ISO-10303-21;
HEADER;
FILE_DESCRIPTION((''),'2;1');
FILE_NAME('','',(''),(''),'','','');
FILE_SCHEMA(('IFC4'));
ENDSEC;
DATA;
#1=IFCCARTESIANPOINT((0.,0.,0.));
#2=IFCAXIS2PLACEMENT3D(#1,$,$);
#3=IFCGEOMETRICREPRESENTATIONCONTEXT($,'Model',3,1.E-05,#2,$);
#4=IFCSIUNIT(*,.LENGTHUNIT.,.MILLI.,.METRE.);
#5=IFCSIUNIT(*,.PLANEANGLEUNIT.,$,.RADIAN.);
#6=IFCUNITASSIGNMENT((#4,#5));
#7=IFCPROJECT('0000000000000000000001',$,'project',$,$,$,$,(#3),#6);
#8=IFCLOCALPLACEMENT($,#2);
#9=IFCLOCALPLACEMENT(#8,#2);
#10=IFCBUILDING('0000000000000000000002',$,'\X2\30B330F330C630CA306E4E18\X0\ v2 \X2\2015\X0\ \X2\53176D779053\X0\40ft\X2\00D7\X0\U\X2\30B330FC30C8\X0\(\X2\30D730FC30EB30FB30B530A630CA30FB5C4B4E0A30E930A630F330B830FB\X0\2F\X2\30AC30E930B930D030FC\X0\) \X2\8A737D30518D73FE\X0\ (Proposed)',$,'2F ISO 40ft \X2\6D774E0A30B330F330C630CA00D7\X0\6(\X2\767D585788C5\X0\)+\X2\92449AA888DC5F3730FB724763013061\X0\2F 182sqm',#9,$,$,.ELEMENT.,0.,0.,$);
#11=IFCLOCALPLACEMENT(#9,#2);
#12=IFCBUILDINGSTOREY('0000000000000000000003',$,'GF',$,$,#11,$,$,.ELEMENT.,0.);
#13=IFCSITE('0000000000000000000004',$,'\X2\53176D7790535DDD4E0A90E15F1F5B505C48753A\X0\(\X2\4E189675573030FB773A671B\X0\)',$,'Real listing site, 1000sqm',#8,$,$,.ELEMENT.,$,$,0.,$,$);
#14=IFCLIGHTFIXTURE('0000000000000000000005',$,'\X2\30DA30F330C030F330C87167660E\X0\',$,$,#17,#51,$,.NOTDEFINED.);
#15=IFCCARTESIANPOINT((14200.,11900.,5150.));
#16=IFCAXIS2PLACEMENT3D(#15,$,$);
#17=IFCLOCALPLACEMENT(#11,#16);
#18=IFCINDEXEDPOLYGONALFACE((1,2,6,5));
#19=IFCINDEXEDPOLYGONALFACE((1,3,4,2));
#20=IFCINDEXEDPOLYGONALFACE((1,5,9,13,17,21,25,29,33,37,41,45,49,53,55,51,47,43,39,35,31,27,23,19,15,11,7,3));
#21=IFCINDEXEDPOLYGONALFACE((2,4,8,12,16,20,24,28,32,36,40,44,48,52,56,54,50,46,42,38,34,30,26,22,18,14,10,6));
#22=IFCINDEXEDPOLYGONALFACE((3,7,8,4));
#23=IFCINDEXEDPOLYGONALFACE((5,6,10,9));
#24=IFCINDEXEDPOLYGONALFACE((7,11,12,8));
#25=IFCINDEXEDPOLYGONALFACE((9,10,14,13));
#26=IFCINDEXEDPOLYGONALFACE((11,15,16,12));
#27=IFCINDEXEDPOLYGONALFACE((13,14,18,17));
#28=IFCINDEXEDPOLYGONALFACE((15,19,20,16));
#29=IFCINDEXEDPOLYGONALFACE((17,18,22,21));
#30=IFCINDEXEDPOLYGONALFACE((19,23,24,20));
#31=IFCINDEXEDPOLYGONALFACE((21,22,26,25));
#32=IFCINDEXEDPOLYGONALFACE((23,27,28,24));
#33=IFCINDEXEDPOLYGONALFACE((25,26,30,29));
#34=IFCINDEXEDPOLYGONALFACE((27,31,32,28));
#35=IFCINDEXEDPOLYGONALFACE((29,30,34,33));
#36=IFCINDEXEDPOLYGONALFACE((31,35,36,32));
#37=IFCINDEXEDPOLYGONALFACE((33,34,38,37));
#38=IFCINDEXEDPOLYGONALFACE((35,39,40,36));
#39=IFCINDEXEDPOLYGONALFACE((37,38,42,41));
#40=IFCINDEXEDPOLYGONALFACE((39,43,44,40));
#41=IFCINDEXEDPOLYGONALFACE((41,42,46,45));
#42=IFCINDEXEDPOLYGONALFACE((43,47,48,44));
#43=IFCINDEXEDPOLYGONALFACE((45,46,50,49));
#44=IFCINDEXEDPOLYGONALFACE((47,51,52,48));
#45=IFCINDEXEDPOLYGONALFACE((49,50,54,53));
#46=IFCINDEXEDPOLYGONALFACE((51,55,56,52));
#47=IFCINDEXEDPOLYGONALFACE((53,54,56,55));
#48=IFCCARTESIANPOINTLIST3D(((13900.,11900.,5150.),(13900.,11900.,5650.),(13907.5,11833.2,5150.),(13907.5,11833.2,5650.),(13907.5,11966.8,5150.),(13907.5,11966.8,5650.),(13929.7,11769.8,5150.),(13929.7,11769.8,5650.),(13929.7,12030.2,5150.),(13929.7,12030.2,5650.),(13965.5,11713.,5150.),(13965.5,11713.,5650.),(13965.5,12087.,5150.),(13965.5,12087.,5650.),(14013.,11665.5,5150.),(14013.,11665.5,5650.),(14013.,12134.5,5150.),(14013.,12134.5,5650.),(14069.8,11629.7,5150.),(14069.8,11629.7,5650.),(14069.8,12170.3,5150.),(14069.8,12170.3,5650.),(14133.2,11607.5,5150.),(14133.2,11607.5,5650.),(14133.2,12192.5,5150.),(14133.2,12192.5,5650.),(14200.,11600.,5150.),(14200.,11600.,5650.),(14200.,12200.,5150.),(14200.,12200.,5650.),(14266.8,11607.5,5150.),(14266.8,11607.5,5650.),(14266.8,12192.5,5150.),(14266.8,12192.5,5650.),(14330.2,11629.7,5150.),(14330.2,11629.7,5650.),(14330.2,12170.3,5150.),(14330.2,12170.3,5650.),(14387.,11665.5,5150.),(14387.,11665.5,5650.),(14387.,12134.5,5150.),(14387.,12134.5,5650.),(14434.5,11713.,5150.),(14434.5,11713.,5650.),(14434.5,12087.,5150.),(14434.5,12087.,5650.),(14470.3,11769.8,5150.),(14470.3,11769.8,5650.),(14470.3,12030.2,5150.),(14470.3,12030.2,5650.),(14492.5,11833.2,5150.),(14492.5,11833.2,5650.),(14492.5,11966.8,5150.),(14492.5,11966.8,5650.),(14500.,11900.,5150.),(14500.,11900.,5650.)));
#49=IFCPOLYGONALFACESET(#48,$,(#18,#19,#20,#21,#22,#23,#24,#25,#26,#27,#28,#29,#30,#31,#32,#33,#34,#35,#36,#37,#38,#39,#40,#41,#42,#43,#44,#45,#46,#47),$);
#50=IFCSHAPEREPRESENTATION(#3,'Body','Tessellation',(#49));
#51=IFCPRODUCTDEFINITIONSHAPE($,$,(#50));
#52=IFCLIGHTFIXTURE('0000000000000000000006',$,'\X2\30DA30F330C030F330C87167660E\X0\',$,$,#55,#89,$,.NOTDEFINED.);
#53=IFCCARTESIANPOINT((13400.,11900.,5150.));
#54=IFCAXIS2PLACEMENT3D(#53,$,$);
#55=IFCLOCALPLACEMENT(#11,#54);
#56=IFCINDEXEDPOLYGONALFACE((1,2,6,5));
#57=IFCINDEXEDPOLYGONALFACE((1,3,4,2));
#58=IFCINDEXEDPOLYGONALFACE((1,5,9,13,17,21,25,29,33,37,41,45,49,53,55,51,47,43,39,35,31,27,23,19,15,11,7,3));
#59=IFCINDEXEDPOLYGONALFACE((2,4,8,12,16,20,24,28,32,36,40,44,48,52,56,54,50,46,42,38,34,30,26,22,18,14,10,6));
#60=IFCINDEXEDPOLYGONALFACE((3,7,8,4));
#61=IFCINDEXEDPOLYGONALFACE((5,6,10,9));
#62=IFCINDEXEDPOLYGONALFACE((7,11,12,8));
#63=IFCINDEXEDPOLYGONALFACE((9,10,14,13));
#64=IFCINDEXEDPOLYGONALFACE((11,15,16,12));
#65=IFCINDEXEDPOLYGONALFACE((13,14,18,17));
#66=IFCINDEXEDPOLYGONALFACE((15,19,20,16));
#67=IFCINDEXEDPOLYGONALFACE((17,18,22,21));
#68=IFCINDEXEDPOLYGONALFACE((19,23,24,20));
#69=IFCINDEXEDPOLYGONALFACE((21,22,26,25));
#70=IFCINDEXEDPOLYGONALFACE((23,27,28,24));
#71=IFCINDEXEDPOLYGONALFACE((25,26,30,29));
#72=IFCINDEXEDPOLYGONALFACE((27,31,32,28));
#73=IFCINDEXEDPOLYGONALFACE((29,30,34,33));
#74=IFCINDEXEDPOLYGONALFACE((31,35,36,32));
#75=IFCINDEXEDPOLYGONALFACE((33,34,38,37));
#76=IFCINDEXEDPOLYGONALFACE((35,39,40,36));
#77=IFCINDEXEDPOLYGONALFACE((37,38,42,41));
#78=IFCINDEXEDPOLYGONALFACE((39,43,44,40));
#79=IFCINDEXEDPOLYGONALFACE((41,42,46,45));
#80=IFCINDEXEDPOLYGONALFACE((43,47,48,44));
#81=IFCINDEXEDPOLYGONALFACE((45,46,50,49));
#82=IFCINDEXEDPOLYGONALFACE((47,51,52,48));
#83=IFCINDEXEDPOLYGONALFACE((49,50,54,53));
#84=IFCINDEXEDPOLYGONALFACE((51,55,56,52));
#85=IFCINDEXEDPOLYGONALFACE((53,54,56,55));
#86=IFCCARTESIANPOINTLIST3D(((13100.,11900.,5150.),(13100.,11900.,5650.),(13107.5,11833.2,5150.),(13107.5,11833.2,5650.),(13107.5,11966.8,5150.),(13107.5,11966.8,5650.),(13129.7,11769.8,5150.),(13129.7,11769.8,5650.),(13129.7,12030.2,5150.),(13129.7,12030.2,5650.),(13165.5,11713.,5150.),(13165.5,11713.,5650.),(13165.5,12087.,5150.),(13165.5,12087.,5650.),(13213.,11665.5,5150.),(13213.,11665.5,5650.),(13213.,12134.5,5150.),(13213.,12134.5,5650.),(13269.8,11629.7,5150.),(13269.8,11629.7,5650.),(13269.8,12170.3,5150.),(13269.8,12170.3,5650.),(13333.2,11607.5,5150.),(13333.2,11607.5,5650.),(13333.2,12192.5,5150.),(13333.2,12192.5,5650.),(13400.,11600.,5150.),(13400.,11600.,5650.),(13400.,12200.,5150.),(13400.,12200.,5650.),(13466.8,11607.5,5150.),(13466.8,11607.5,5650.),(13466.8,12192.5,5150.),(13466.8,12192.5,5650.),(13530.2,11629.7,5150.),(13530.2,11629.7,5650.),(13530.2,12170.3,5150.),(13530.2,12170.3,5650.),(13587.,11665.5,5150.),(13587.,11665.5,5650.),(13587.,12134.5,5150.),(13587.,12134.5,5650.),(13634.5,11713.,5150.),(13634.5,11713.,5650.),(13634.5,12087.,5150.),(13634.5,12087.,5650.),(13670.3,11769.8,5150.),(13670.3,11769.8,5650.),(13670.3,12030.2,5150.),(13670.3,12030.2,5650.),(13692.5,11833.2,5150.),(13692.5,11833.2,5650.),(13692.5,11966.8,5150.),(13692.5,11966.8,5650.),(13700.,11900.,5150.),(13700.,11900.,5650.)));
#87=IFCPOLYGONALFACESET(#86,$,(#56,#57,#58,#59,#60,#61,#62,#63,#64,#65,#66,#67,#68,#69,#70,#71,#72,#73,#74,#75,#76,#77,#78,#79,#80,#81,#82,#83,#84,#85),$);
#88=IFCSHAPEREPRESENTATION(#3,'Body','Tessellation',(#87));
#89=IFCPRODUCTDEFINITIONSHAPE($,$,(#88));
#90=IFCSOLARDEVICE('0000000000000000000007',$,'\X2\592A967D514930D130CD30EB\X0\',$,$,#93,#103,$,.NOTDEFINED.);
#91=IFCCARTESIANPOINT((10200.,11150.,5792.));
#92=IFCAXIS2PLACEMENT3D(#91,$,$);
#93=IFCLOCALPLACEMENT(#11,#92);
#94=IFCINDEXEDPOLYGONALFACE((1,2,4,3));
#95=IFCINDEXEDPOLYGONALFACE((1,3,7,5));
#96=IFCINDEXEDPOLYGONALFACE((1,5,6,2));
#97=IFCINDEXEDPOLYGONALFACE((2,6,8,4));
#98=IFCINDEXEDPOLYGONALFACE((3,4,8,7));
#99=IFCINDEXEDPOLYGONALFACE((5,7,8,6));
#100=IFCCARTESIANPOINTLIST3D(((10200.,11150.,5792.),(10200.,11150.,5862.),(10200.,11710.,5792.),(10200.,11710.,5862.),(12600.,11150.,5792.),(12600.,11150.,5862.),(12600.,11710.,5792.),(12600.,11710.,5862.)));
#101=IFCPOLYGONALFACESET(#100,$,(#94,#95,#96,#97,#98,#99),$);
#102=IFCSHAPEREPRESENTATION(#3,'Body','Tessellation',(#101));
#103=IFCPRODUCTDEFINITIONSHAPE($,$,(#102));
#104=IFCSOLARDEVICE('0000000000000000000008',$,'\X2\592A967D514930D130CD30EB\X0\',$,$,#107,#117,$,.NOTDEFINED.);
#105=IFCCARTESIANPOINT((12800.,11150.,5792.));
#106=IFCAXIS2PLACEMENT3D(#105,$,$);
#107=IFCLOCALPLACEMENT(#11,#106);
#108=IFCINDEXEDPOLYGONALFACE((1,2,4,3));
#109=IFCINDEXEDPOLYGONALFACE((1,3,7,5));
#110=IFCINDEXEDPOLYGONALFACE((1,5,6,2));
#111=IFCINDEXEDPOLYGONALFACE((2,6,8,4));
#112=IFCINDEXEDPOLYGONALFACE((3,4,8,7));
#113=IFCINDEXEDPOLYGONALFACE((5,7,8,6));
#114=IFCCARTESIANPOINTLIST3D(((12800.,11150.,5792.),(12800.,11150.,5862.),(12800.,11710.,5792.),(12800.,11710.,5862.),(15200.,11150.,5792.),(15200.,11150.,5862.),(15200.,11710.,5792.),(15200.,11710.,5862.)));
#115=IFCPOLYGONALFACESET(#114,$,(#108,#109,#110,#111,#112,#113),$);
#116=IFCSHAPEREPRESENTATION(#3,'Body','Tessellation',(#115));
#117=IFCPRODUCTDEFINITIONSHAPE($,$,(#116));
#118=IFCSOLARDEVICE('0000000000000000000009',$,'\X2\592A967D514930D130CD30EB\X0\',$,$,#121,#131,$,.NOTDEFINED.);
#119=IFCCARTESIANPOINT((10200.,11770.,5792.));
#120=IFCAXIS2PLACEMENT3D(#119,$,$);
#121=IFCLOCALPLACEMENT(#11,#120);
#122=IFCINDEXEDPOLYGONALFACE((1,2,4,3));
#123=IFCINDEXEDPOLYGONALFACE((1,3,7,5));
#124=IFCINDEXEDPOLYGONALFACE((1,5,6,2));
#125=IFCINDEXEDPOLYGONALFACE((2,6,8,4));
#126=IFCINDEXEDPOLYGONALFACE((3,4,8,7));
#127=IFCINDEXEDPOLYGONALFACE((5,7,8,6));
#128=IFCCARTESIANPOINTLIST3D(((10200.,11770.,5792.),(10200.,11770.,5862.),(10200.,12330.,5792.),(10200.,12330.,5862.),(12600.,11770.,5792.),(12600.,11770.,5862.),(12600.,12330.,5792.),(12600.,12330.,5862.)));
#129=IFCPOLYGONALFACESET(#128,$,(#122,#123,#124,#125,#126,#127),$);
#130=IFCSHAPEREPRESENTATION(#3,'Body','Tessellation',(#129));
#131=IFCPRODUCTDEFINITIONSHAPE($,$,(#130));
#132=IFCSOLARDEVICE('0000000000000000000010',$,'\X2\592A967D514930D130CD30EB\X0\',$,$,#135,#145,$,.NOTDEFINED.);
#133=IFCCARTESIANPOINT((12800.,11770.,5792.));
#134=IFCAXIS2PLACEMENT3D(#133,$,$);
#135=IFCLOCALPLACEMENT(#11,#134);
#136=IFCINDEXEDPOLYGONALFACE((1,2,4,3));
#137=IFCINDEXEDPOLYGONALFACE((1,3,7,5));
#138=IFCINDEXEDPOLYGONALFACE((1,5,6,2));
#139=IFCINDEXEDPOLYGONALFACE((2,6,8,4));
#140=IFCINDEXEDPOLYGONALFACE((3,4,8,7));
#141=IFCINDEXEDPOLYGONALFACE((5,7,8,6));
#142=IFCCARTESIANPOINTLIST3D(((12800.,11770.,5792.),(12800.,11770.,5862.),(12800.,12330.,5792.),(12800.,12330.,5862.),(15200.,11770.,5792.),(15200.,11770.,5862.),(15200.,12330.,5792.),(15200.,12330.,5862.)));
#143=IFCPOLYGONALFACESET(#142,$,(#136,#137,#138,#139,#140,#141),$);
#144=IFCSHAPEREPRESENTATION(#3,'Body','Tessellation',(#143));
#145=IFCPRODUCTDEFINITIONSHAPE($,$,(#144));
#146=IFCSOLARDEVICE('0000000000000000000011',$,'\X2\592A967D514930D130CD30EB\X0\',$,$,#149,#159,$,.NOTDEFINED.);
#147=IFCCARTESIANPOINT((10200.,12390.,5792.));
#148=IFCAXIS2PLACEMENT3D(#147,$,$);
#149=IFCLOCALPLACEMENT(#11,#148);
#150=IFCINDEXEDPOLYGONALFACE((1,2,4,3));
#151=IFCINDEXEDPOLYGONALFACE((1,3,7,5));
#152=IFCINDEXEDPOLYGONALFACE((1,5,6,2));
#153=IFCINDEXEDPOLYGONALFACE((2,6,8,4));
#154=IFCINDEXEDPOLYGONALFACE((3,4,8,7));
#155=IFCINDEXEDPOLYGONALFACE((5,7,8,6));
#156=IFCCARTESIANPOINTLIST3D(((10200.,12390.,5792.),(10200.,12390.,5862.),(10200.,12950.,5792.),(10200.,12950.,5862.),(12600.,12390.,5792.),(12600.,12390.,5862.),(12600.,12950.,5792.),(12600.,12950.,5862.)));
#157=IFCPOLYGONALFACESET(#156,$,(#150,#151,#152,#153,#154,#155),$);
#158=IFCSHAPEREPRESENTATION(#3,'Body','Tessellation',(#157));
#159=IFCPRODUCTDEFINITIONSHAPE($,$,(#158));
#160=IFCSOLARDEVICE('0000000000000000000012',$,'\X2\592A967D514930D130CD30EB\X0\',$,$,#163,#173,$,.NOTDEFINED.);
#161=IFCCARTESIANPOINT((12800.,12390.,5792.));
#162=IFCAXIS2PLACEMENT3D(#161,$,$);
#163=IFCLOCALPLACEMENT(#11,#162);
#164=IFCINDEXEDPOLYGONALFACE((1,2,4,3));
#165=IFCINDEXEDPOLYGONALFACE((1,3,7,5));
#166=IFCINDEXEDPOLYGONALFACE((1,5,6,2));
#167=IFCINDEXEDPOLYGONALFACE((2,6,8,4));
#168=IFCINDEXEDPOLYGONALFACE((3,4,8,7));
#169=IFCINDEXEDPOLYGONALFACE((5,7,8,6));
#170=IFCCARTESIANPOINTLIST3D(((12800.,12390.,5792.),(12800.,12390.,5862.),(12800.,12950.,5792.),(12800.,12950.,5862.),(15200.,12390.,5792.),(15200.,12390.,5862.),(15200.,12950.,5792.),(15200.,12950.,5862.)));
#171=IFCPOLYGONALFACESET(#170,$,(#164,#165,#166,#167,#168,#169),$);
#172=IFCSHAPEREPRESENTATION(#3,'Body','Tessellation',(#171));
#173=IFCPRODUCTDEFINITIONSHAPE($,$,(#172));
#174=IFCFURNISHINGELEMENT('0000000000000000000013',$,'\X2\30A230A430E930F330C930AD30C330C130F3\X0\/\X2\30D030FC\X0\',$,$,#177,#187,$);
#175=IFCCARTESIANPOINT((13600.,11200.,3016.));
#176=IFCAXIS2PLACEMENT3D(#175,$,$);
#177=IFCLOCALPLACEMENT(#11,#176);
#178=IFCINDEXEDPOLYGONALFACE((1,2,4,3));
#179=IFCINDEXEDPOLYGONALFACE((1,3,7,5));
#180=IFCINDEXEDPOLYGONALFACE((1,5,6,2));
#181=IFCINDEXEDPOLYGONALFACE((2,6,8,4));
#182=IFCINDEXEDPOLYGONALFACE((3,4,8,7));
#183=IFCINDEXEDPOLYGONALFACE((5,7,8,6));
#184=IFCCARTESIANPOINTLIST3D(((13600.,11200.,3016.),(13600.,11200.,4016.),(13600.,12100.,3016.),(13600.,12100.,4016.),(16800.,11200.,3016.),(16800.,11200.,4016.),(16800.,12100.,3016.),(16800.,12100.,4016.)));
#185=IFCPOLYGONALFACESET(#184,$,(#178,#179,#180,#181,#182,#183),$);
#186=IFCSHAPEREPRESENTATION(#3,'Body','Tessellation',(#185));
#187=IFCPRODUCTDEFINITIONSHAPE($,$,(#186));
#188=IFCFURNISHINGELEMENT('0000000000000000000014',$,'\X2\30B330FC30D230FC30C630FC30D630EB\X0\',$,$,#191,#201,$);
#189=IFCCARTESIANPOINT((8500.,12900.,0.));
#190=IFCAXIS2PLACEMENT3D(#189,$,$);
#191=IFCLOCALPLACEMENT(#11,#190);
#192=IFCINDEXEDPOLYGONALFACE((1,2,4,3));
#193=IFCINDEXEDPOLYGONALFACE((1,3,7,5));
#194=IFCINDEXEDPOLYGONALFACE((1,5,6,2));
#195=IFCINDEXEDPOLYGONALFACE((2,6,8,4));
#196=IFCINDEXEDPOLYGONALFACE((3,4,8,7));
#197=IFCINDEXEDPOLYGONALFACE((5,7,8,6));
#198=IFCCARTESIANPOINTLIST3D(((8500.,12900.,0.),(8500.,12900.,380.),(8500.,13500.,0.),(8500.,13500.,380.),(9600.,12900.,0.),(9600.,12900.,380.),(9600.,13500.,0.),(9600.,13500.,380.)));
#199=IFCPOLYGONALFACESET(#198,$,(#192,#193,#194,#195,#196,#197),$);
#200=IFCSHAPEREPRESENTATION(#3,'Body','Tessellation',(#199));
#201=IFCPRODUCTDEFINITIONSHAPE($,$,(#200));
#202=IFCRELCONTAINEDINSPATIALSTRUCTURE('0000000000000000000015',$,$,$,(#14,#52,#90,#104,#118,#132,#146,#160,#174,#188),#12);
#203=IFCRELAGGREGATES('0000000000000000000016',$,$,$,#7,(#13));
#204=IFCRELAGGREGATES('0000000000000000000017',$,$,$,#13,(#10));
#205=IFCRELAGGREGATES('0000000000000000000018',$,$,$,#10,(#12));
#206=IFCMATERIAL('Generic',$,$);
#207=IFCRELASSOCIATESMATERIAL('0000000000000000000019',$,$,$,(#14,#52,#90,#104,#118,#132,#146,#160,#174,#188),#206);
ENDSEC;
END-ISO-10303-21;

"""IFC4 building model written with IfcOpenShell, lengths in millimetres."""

from ifc_helpers import new_model, si_unit, frame, frame_2d, origin, origin_2d, place, context, project, spatial, rectangle, circle, extrude, material, element, save


model = new_model("IFC4")

# Units and contexts
model_context = context("Model", 3, precision=1e-05, world=origin())
ifc_project = project(units=[si_unit("LENGTHUNIT", "METRE", prefix="MILLI"), si_unit("PLANEANGLEUNIT", "RADIAN")], contexts=[model_context])

# Site, building, storey
site_placement = place(None, origin())
site = spatial("IfcSite", under=ifc_project, at=site_placement, Name="北海道川上郡弟子屈町(丘陵地・眺望)", ObjectType="Real listing site, 1000sqm", CompositionType="ELEMENT", RefElevation=0.0)
building_placement = place(site_placement, origin())
building = spatial("IfcBuilding", under=site, at=building_placement, Name="コンテナの丘 v2 ― 北海道40ft×Uコート(プール・サウナ・屋上ラウンジ・2Fガラスバー) 詳細再現 (Proposed)", ObjectType="2F ISO 40ft 海上コンテナ×6(白塗装)+鉄骨補強・片持ち2F 182sqm", CompositionType="ELEMENT", ElevationOfRefHeight=0.0, ElevationOfTerrain=0.0)
storey_placement = place(building_placement, origin())
storey = spatial("IfcBuildingStorey", under=building, at=storey_placement, Name="GF", CompositionType="ELEMENT", Elevation=0.0)

# Shared definitions
ifc_material = material(Name="Generic")

# Light fixtures
light_fixture_1_placement = place(storey_placement, frame((14200.0, 11900.0, 5150.0)))
element("IfcLightFixture", 1, at=light_fixture_1_placement, inside=storey, material=ifc_material, Name="ペンダント照明", PredefinedType="NOTDEFINED", context=model_context, shape_type="SweptSolid", body=[
    extrude(circle(Radius=300.0, at=origin_2d()), frame((14200.0, 11900.0, 5150.0)), (0.0, 0.0, 1.0), 500.0),
])
light_fixture_2_placement = place(storey_placement, frame((13400.0, 11900.0, 5150.0)))
element("IfcLightFixture", 2, at=light_fixture_2_placement, inside=storey, material=ifc_material, Name="ペンダント照明", PredefinedType="NOTDEFINED", context=model_context, shape_type="SweptSolid", body=[
    extrude(circle(Radius=300.0, at=origin_2d()), frame((13400.0, 11900.0, 5150.0)), (0.0, 0.0, 1.0), 500.0),
])

# Solar devices
solar_device_1_placement = place(storey_placement, frame((10200.0, 11150.0, 5792.0)))
element("IfcSolarDevice", 3, at=solar_device_1_placement, inside=storey, material=ifc_material, Name="太陽光パネル", PredefinedType="NOTDEFINED", context=model_context, shape_type="SweptSolid", body=[
    extrude(rectangle(XDim=2400.0, YDim=560.0, at=frame_2d((1200.0, 280.0))), frame((10200.0, 11150.0, 5792.0)), (0.0, 0.0, 1.0), 70.0),
])
solar_device_2_placement = place(storey_placement, frame((12800.0, 11150.0, 5792.0)))
element("IfcSolarDevice", 4, at=solar_device_2_placement, inside=storey, material=ifc_material, Name="太陽光パネル", PredefinedType="NOTDEFINED", context=model_context, shape_type="SweptSolid", body=[
    extrude(rectangle(XDim=2400.0, YDim=560.0, at=frame_2d((1200.0, 280.0))), frame((12800.0, 11150.0, 5792.0)), (0.0, 0.0, 1.0), 70.0),
])
solar_device_3_placement = place(storey_placement, frame((10200.0, 11770.0, 5792.0)))
element("IfcSolarDevice", 5, at=solar_device_3_placement, inside=storey, material=ifc_material, Name="太陽光パネル", PredefinedType="NOTDEFINED", context=model_context, shape_type="SweptSolid", body=[
    extrude(rectangle(XDim=2400.0, YDim=560.0, at=frame_2d((1200.0, 280.0))), frame((10200.0, 11770.0, 5792.0)), (0.0, 0.0, 1.0), 70.0),
])
solar_device_4_placement = place(storey_placement, frame((12800.0, 11770.0, 5792.0)))
element("IfcSolarDevice", 6, at=solar_device_4_placement, inside=storey, material=ifc_material, Name="太陽光パネル", PredefinedType="NOTDEFINED", context=model_context, shape_type="SweptSolid", body=[
    extrude(rectangle(XDim=2400.0, YDim=560.0, at=frame_2d((1200.0, 280.0))), frame((12800.0, 11770.0, 5792.0)), (0.0, 0.0, 1.0), 70.0),
])
solar_device_5_placement = place(storey_placement, frame((10200.0, 12390.0, 5792.0)))
element("IfcSolarDevice", 7, at=solar_device_5_placement, inside=storey, material=ifc_material, Name="太陽光パネル", PredefinedType="NOTDEFINED", context=model_context, shape_type="SweptSolid", body=[
    extrude(rectangle(XDim=2400.0, YDim=560.0, at=frame_2d((1200.0, 280.0))), frame((10200.0, 12390.0, 5792.0)), (0.0, 0.0, 1.0), 70.0),
])
solar_device_6_placement = place(storey_placement, frame((12800.0, 12390.0, 5792.0)))
element("IfcSolarDevice", 8, at=solar_device_6_placement, inside=storey, material=ifc_material, Name="太陽光パネル", PredefinedType="NOTDEFINED", context=model_context, shape_type="SweptSolid", body=[
    extrude(rectangle(XDim=2400.0, YDim=560.0, at=frame_2d((1200.0, 280.0))), frame((12800.0, 12390.0, 5792.0)), (0.0, 0.0, 1.0), 70.0),
])

# Furnishing elements
furnishing_1_placement = place(storey_placement, frame((13600.0, 11200.0, 3016.0)))
element("IfcFurnishingElement", 9, at=furnishing_1_placement, inside=storey, material=ifc_material, Name="アイランドキッチン/バー", context=model_context, shape_type="SweptSolid", body=[
    extrude(rectangle(XDim=3200.0, YDim=900.0, at=frame_2d((1600.0, 450.0))), frame((13600.0, 11200.0, 3016.0)), (0.0, 0.0, 1.0), 1000.0),
])
furnishing_2_placement = place(storey_placement, frame((8500.0, 12900.0, 0.0)))
element("IfcFurnishingElement", 10, at=furnishing_2_placement, inside=storey, material=ifc_material, Name="コーヒーテーブル", context=model_context, shape_type="SweptSolid", body=[
    extrude(rectangle(XDim=1100.0, YDim=600.0, at=frame_2d((550.0, 300.0))), frame((8500.0, 12900.0, 0.0)), (0.0, 0.0, 1.0), 380.0),
])

save(model, "model.ifc")
